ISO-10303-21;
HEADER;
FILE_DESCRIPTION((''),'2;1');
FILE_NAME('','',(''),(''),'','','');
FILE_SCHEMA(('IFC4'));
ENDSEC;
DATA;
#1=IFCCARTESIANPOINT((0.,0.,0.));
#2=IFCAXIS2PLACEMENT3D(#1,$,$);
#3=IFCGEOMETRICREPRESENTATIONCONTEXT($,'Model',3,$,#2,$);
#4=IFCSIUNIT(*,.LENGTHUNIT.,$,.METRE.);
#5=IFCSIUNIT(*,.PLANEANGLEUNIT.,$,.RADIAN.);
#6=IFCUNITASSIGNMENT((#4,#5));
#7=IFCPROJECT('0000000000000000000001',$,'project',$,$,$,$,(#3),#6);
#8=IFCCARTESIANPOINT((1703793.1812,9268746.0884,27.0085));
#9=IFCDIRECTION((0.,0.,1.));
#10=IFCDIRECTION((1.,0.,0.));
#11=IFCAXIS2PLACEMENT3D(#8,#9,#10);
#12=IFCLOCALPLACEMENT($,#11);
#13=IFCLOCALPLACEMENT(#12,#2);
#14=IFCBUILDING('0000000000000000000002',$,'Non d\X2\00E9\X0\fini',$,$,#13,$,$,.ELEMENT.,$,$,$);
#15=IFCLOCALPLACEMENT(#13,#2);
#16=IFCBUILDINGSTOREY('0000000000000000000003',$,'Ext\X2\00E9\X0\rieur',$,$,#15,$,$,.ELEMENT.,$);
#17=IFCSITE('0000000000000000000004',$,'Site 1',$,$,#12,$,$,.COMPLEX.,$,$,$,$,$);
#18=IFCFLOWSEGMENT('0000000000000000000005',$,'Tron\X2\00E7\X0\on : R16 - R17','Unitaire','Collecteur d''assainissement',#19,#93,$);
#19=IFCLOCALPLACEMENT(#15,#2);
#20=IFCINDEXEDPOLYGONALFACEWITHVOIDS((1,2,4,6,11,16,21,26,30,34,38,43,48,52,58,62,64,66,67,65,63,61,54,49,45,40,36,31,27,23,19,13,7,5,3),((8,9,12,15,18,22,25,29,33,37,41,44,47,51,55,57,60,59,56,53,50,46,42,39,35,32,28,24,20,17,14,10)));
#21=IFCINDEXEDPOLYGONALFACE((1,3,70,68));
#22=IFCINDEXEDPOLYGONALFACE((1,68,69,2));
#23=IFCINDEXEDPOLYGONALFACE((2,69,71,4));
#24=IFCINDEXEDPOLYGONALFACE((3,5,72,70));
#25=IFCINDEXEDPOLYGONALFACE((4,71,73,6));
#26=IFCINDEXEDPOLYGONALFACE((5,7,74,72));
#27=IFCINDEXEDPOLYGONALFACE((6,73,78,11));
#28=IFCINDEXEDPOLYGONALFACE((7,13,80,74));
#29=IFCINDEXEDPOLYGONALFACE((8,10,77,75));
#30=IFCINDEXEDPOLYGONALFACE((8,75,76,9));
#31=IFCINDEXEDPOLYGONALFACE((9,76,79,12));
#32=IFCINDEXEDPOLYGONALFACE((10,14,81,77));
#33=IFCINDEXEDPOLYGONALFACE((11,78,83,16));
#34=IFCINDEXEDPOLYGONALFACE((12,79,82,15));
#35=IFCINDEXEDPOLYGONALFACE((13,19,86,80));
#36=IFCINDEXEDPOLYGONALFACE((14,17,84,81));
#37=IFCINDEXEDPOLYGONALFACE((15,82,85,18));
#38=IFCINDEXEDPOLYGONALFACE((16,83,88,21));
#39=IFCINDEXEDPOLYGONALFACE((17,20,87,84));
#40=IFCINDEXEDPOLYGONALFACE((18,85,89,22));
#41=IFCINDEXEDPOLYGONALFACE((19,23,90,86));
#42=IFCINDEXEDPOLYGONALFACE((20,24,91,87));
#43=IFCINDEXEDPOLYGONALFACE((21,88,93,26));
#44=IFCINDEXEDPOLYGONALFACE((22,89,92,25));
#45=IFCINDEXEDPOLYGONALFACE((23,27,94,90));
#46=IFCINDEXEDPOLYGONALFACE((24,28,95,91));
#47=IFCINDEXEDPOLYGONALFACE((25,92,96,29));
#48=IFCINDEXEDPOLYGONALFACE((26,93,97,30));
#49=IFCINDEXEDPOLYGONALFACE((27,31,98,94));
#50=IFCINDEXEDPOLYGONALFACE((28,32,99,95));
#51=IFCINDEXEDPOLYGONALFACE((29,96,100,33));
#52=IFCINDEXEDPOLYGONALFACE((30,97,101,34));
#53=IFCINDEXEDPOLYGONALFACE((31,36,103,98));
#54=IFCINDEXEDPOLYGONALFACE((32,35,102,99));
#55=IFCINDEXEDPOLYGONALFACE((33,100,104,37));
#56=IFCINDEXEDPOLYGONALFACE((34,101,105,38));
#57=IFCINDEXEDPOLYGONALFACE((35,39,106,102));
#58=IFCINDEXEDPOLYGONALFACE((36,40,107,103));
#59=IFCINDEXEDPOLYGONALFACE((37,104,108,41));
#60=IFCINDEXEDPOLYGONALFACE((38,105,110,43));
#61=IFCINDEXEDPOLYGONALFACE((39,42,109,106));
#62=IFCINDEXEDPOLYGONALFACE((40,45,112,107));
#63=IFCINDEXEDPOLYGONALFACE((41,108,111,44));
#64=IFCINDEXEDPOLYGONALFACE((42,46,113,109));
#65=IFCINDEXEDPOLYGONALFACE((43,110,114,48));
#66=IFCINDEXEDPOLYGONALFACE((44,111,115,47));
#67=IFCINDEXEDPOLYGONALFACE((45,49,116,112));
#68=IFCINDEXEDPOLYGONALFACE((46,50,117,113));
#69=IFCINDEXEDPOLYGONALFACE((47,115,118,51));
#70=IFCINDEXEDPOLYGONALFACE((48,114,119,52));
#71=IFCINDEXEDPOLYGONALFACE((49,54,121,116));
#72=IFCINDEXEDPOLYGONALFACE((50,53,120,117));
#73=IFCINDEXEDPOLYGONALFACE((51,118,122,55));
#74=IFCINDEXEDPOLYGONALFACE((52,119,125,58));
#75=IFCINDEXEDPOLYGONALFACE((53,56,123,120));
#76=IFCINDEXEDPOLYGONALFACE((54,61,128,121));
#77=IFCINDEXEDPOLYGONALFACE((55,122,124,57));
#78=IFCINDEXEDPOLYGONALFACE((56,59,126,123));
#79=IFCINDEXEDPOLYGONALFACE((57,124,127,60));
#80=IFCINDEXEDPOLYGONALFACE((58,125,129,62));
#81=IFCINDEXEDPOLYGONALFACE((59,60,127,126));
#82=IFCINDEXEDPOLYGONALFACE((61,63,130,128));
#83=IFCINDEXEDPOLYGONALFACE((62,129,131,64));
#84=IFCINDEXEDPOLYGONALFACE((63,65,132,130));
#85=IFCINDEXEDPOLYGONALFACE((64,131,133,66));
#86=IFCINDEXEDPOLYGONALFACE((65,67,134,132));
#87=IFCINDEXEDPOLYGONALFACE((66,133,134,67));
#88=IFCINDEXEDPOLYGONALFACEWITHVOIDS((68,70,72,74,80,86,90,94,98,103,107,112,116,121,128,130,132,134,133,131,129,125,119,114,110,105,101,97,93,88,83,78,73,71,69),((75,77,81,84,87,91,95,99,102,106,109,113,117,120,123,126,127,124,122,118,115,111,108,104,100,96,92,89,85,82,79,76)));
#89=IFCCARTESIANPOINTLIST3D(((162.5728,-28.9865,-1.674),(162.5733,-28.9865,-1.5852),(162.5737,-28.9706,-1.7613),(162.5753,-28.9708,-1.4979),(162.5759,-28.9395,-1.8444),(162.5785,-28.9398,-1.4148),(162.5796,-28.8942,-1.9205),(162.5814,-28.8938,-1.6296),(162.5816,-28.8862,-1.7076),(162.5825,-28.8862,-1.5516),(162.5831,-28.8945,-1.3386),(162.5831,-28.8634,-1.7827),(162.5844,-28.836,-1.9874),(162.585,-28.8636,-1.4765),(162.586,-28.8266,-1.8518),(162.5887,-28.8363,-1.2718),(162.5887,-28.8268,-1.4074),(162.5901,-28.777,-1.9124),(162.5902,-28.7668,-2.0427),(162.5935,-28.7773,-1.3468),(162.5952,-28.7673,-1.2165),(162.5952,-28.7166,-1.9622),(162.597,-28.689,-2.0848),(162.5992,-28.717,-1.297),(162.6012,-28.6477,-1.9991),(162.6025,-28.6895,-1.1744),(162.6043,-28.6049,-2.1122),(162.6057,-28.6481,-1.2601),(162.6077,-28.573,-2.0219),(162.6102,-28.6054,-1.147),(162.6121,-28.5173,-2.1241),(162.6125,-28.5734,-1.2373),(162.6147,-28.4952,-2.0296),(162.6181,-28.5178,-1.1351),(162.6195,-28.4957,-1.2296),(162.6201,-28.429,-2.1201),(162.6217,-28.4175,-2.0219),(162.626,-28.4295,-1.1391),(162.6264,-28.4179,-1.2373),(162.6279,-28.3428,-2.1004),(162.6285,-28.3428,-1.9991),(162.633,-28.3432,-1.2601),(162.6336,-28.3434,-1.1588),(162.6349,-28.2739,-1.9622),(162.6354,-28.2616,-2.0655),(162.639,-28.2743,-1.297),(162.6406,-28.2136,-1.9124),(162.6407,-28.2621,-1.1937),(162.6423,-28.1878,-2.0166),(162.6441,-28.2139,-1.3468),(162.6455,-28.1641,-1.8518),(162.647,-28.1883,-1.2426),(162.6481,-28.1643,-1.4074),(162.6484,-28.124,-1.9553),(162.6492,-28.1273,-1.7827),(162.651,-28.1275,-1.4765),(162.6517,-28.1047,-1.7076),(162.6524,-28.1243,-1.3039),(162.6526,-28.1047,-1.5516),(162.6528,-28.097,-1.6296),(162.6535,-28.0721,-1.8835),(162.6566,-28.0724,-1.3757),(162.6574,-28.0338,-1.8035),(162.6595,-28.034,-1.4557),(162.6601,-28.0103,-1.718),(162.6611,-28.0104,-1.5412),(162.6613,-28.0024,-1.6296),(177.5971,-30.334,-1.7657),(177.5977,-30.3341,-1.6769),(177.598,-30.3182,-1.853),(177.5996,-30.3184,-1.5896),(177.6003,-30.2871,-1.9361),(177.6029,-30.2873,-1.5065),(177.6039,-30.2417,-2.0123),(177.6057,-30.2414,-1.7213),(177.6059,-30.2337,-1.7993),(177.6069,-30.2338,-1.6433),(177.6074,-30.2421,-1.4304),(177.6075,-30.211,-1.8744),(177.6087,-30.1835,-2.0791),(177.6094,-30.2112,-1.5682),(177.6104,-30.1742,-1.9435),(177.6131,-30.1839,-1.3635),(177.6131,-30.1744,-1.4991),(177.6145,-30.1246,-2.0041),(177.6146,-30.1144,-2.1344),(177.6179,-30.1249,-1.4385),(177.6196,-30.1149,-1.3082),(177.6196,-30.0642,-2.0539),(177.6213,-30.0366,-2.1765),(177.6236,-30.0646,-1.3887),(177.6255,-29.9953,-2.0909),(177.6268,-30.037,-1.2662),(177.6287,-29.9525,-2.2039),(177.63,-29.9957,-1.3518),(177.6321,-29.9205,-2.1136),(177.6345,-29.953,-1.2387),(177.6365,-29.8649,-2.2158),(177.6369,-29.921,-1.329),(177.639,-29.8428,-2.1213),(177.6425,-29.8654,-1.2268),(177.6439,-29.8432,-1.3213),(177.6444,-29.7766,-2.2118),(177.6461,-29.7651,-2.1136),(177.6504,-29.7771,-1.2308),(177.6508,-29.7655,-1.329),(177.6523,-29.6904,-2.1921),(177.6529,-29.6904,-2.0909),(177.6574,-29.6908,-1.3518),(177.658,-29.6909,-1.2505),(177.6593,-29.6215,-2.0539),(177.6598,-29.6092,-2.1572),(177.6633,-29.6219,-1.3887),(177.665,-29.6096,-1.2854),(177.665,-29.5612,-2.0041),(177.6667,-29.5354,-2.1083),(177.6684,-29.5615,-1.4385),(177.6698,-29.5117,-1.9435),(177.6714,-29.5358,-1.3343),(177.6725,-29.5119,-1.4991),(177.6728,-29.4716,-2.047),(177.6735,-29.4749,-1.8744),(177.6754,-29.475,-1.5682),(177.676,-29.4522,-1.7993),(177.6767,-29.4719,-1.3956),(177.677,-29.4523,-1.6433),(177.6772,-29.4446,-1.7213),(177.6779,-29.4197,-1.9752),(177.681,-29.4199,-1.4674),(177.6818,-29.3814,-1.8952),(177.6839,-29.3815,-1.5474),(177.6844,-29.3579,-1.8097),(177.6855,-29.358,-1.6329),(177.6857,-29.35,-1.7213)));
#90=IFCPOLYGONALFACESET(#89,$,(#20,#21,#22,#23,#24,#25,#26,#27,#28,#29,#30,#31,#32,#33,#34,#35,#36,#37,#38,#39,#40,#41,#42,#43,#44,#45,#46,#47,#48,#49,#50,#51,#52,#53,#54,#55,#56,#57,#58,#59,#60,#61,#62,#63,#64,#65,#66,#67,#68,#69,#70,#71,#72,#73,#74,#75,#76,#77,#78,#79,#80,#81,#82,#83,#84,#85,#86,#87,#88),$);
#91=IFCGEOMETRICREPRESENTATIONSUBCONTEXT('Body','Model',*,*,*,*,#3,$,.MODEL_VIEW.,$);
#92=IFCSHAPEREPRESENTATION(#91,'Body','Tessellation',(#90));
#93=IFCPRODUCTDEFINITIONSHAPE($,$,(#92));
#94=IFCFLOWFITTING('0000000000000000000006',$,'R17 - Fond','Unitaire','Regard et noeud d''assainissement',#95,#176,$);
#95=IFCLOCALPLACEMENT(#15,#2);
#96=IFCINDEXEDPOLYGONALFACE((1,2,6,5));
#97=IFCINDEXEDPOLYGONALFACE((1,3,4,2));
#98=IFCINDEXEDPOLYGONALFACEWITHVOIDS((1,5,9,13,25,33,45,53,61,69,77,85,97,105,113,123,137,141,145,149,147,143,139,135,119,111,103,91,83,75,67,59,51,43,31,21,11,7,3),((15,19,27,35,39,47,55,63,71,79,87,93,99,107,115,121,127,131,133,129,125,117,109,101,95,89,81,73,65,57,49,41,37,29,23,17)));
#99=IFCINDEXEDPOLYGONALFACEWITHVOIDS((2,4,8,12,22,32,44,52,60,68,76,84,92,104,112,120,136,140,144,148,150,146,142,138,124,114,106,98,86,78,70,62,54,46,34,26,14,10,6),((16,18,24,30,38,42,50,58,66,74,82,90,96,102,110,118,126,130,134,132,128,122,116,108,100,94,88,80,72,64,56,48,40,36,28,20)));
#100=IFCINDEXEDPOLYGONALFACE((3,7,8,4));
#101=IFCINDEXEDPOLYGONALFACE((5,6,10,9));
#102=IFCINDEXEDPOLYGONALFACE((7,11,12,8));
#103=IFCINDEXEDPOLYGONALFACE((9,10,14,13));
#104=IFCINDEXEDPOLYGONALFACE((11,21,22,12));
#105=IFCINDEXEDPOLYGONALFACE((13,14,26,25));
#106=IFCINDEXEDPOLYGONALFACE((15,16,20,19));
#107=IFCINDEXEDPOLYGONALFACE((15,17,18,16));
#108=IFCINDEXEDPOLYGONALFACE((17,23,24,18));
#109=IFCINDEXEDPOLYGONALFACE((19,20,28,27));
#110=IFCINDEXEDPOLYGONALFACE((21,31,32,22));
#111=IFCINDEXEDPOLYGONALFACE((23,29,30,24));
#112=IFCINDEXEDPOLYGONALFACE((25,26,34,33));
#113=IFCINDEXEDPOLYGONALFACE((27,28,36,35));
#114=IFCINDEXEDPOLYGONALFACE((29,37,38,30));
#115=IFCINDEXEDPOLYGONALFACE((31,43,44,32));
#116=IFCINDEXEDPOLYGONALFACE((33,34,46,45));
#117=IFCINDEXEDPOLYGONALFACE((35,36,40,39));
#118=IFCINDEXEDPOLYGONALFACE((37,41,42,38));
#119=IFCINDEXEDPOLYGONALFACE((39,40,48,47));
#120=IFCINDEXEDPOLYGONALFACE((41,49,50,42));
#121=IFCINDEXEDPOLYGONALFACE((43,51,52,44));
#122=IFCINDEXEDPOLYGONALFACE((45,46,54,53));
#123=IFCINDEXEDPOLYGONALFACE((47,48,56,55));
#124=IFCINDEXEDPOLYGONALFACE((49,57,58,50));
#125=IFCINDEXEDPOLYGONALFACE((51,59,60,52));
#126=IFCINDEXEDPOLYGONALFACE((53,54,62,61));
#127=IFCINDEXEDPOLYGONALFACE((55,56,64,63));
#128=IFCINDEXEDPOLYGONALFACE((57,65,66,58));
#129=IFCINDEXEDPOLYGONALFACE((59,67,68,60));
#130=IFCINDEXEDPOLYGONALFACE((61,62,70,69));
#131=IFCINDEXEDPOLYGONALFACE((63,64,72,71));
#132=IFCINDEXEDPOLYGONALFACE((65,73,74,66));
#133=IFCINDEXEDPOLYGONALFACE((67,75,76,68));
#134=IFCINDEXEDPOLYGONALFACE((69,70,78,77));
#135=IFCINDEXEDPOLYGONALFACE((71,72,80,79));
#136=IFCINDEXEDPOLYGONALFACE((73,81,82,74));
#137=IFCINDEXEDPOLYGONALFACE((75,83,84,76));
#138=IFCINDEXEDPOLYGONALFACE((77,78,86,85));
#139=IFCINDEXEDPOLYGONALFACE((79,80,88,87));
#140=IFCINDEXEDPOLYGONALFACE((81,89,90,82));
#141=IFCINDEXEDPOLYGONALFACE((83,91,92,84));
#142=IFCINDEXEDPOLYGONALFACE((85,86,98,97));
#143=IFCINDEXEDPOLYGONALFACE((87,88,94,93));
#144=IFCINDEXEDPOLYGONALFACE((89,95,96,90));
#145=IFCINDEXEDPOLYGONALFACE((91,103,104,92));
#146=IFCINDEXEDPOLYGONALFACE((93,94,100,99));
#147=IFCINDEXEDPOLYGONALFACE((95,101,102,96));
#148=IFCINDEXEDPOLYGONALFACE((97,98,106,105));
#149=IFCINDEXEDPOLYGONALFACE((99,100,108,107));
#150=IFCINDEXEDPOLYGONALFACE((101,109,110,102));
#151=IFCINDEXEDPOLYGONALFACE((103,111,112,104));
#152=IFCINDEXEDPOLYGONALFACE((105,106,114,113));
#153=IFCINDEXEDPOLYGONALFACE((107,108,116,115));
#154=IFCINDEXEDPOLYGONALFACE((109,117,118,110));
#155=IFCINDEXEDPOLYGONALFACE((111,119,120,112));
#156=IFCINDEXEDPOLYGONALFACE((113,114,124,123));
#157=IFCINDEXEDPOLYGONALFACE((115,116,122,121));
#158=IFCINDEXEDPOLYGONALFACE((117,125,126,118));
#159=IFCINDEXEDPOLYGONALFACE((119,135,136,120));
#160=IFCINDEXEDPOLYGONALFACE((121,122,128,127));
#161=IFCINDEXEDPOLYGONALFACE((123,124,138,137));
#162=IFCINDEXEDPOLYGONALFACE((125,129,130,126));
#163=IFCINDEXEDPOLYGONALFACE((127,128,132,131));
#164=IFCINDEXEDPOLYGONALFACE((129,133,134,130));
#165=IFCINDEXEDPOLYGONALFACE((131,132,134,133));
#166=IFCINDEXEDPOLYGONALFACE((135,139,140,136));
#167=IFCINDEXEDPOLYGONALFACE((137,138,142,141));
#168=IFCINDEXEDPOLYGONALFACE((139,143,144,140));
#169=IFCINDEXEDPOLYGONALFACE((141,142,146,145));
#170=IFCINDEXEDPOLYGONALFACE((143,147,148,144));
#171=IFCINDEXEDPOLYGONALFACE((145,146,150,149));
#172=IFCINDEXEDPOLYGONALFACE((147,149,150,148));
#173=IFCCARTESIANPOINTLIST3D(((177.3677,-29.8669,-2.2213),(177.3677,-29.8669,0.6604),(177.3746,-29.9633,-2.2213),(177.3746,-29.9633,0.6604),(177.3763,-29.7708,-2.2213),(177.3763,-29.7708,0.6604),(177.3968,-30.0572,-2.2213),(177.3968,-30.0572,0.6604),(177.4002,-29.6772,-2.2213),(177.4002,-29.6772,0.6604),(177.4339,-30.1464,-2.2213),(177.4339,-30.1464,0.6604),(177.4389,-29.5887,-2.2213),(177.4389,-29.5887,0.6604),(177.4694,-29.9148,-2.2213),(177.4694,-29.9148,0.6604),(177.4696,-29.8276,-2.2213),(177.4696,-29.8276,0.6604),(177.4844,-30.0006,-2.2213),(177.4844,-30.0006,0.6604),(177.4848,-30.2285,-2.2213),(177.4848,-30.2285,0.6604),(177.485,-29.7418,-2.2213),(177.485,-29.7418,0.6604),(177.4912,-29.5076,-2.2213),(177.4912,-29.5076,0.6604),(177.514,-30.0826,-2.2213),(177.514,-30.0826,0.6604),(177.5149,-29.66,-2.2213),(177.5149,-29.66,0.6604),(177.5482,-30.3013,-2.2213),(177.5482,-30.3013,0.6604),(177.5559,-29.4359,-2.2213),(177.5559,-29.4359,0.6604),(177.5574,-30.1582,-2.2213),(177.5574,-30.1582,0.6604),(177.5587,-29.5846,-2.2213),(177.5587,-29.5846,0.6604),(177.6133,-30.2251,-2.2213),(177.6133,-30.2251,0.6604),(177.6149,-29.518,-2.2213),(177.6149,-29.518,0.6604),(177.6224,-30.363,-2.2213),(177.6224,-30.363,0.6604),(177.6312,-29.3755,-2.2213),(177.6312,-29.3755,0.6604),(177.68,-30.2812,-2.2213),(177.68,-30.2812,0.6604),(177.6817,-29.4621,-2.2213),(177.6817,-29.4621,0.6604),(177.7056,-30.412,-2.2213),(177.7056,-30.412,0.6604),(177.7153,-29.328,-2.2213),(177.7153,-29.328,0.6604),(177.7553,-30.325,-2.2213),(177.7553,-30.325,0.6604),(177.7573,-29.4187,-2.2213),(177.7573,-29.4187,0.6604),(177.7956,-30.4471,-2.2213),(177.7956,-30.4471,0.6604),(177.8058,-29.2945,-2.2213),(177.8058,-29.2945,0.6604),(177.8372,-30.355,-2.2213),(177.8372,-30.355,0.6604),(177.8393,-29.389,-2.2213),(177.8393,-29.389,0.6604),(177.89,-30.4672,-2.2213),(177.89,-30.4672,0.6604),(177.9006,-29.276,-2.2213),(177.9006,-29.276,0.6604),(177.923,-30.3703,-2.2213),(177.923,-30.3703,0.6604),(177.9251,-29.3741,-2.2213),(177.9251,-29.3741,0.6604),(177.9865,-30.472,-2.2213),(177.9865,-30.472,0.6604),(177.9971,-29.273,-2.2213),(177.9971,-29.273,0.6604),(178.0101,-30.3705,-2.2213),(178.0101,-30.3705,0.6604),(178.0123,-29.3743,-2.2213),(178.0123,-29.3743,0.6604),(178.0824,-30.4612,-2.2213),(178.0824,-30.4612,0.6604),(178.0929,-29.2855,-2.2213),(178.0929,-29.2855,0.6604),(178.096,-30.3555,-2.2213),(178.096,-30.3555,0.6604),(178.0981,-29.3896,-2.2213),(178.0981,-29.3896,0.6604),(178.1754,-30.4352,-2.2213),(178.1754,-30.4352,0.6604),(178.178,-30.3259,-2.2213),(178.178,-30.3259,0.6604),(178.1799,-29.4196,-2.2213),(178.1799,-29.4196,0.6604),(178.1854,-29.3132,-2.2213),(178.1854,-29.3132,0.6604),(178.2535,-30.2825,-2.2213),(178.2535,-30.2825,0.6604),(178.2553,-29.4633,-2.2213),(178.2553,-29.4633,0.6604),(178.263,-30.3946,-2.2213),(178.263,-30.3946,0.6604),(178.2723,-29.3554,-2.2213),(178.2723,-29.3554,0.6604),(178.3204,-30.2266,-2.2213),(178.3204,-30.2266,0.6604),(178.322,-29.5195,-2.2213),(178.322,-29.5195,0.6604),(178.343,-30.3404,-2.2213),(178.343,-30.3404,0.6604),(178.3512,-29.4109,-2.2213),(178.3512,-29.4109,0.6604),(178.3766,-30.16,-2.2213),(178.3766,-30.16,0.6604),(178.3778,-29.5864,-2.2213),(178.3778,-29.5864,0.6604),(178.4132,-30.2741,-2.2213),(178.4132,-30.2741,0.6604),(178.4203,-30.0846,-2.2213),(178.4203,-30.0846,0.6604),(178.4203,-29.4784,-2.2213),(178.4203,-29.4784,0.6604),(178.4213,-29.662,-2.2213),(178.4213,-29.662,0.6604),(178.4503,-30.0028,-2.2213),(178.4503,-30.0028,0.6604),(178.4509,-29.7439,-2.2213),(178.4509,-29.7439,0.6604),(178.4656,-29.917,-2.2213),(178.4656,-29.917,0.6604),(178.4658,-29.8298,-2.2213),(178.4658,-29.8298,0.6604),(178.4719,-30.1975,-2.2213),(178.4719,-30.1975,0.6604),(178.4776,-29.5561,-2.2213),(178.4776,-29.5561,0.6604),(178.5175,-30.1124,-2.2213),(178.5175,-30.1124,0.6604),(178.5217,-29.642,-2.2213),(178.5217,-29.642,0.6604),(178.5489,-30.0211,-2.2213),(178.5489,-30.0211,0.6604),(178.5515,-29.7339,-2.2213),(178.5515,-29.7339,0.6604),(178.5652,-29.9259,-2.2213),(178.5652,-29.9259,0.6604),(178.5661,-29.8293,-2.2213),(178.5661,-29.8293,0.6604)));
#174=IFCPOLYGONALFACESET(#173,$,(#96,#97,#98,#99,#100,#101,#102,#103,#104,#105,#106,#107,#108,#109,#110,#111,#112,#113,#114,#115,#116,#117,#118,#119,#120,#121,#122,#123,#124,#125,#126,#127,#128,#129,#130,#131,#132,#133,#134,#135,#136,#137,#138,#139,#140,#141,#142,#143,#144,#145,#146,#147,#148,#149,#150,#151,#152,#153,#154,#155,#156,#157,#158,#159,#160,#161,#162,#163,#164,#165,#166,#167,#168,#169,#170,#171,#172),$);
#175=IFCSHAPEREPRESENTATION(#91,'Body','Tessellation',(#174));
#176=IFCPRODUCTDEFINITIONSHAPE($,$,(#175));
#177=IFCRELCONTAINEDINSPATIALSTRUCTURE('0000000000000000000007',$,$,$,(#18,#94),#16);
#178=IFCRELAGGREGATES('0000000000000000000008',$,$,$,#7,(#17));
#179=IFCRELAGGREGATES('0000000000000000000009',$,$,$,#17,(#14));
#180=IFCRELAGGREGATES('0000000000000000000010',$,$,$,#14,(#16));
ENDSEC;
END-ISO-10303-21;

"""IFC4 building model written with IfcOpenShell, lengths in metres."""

from ifc_helpers import new_model, si_unit, frame, origin, origin_2d, place, context, subcontext, project, spatial, hollow_circle, extrude, element, save


model = new_model("IFC4")

# Units and contexts
model_context = context("Model", 3, world=origin())
body_context = subcontext(model_context, "Body", "Model", "MODEL_VIEW")
ifc_project = project(units=[si_unit("LENGTHUNIT", "METRE"), si_unit("PLANEANGLEUNIT", "RADIAN")], contexts=[model_context])

# Site, building, storey
site_placement = place(None, frame((1703793.1812, 9268746.0884, 27.0085), z_axis=(0.0, 0.0, 1.0), x_axis=(1.0, 0.0, 0.0)))
site = spatial("IfcSite", under=ifc_project, at=site_placement, Name="Site 1", CompositionType="COMPLEX")
building_placement = place(site_placement, origin())
building = spatial("IfcBuilding", under=site, at=building_placement, Name="Non défini", CompositionType="ELEMENT")
storey_placement = place(building_placement, origin())
storey = spatial("IfcBuildingStorey", under=building, at=storey_placement, Name="Extérieur", CompositionType="ELEMENT")

# Flow segment
flow_segment_1_placement = place(storey_placement, origin())
element("IfcFlowSegment", 1, at=flow_segment_1_placement, inside=storey, Name="Tronçon : R16 - R17", Description="Unitaire", ObjectType="Collecteur d'assainissement", context=body_context, shape_type="SweptSolid", body=[
    extrude(hollow_circle(Radius=0.495, WallThickness=0.095, at=origin_2d()), frame((162.6171, -28.4954, -1.6296), z_axis=(0.995983, -0.089333, -0.00608), x_axis=(0.089335, 0.996002, 0.0)), (0.0, 0.0, 1.0), 15.085),
])

# Flow fitting
flow_fitting_1_placement = place(storey_placement, origin())
element("IfcFlowFitting", 2, at=flow_fitting_1_placement, inside=storey, Name="R17 - Fond", Description="Unitaire", ObjectType="Regard et noeud d'assainissement", context=body_context, shape_type="SweptSolid", body=[
    extrude(hollow_circle(Radius=0.6, WallThickness=0.1, at=origin_2d()), frame((177.9676, -29.8723, -2.2213), z_axis=(0.0, 0.0, 1.0), x_axis=(0.996002, -0.089335, 0.0)), (0.0, 0.0, 1.0), 2.8817),
])

save(model, "model.ifc")
